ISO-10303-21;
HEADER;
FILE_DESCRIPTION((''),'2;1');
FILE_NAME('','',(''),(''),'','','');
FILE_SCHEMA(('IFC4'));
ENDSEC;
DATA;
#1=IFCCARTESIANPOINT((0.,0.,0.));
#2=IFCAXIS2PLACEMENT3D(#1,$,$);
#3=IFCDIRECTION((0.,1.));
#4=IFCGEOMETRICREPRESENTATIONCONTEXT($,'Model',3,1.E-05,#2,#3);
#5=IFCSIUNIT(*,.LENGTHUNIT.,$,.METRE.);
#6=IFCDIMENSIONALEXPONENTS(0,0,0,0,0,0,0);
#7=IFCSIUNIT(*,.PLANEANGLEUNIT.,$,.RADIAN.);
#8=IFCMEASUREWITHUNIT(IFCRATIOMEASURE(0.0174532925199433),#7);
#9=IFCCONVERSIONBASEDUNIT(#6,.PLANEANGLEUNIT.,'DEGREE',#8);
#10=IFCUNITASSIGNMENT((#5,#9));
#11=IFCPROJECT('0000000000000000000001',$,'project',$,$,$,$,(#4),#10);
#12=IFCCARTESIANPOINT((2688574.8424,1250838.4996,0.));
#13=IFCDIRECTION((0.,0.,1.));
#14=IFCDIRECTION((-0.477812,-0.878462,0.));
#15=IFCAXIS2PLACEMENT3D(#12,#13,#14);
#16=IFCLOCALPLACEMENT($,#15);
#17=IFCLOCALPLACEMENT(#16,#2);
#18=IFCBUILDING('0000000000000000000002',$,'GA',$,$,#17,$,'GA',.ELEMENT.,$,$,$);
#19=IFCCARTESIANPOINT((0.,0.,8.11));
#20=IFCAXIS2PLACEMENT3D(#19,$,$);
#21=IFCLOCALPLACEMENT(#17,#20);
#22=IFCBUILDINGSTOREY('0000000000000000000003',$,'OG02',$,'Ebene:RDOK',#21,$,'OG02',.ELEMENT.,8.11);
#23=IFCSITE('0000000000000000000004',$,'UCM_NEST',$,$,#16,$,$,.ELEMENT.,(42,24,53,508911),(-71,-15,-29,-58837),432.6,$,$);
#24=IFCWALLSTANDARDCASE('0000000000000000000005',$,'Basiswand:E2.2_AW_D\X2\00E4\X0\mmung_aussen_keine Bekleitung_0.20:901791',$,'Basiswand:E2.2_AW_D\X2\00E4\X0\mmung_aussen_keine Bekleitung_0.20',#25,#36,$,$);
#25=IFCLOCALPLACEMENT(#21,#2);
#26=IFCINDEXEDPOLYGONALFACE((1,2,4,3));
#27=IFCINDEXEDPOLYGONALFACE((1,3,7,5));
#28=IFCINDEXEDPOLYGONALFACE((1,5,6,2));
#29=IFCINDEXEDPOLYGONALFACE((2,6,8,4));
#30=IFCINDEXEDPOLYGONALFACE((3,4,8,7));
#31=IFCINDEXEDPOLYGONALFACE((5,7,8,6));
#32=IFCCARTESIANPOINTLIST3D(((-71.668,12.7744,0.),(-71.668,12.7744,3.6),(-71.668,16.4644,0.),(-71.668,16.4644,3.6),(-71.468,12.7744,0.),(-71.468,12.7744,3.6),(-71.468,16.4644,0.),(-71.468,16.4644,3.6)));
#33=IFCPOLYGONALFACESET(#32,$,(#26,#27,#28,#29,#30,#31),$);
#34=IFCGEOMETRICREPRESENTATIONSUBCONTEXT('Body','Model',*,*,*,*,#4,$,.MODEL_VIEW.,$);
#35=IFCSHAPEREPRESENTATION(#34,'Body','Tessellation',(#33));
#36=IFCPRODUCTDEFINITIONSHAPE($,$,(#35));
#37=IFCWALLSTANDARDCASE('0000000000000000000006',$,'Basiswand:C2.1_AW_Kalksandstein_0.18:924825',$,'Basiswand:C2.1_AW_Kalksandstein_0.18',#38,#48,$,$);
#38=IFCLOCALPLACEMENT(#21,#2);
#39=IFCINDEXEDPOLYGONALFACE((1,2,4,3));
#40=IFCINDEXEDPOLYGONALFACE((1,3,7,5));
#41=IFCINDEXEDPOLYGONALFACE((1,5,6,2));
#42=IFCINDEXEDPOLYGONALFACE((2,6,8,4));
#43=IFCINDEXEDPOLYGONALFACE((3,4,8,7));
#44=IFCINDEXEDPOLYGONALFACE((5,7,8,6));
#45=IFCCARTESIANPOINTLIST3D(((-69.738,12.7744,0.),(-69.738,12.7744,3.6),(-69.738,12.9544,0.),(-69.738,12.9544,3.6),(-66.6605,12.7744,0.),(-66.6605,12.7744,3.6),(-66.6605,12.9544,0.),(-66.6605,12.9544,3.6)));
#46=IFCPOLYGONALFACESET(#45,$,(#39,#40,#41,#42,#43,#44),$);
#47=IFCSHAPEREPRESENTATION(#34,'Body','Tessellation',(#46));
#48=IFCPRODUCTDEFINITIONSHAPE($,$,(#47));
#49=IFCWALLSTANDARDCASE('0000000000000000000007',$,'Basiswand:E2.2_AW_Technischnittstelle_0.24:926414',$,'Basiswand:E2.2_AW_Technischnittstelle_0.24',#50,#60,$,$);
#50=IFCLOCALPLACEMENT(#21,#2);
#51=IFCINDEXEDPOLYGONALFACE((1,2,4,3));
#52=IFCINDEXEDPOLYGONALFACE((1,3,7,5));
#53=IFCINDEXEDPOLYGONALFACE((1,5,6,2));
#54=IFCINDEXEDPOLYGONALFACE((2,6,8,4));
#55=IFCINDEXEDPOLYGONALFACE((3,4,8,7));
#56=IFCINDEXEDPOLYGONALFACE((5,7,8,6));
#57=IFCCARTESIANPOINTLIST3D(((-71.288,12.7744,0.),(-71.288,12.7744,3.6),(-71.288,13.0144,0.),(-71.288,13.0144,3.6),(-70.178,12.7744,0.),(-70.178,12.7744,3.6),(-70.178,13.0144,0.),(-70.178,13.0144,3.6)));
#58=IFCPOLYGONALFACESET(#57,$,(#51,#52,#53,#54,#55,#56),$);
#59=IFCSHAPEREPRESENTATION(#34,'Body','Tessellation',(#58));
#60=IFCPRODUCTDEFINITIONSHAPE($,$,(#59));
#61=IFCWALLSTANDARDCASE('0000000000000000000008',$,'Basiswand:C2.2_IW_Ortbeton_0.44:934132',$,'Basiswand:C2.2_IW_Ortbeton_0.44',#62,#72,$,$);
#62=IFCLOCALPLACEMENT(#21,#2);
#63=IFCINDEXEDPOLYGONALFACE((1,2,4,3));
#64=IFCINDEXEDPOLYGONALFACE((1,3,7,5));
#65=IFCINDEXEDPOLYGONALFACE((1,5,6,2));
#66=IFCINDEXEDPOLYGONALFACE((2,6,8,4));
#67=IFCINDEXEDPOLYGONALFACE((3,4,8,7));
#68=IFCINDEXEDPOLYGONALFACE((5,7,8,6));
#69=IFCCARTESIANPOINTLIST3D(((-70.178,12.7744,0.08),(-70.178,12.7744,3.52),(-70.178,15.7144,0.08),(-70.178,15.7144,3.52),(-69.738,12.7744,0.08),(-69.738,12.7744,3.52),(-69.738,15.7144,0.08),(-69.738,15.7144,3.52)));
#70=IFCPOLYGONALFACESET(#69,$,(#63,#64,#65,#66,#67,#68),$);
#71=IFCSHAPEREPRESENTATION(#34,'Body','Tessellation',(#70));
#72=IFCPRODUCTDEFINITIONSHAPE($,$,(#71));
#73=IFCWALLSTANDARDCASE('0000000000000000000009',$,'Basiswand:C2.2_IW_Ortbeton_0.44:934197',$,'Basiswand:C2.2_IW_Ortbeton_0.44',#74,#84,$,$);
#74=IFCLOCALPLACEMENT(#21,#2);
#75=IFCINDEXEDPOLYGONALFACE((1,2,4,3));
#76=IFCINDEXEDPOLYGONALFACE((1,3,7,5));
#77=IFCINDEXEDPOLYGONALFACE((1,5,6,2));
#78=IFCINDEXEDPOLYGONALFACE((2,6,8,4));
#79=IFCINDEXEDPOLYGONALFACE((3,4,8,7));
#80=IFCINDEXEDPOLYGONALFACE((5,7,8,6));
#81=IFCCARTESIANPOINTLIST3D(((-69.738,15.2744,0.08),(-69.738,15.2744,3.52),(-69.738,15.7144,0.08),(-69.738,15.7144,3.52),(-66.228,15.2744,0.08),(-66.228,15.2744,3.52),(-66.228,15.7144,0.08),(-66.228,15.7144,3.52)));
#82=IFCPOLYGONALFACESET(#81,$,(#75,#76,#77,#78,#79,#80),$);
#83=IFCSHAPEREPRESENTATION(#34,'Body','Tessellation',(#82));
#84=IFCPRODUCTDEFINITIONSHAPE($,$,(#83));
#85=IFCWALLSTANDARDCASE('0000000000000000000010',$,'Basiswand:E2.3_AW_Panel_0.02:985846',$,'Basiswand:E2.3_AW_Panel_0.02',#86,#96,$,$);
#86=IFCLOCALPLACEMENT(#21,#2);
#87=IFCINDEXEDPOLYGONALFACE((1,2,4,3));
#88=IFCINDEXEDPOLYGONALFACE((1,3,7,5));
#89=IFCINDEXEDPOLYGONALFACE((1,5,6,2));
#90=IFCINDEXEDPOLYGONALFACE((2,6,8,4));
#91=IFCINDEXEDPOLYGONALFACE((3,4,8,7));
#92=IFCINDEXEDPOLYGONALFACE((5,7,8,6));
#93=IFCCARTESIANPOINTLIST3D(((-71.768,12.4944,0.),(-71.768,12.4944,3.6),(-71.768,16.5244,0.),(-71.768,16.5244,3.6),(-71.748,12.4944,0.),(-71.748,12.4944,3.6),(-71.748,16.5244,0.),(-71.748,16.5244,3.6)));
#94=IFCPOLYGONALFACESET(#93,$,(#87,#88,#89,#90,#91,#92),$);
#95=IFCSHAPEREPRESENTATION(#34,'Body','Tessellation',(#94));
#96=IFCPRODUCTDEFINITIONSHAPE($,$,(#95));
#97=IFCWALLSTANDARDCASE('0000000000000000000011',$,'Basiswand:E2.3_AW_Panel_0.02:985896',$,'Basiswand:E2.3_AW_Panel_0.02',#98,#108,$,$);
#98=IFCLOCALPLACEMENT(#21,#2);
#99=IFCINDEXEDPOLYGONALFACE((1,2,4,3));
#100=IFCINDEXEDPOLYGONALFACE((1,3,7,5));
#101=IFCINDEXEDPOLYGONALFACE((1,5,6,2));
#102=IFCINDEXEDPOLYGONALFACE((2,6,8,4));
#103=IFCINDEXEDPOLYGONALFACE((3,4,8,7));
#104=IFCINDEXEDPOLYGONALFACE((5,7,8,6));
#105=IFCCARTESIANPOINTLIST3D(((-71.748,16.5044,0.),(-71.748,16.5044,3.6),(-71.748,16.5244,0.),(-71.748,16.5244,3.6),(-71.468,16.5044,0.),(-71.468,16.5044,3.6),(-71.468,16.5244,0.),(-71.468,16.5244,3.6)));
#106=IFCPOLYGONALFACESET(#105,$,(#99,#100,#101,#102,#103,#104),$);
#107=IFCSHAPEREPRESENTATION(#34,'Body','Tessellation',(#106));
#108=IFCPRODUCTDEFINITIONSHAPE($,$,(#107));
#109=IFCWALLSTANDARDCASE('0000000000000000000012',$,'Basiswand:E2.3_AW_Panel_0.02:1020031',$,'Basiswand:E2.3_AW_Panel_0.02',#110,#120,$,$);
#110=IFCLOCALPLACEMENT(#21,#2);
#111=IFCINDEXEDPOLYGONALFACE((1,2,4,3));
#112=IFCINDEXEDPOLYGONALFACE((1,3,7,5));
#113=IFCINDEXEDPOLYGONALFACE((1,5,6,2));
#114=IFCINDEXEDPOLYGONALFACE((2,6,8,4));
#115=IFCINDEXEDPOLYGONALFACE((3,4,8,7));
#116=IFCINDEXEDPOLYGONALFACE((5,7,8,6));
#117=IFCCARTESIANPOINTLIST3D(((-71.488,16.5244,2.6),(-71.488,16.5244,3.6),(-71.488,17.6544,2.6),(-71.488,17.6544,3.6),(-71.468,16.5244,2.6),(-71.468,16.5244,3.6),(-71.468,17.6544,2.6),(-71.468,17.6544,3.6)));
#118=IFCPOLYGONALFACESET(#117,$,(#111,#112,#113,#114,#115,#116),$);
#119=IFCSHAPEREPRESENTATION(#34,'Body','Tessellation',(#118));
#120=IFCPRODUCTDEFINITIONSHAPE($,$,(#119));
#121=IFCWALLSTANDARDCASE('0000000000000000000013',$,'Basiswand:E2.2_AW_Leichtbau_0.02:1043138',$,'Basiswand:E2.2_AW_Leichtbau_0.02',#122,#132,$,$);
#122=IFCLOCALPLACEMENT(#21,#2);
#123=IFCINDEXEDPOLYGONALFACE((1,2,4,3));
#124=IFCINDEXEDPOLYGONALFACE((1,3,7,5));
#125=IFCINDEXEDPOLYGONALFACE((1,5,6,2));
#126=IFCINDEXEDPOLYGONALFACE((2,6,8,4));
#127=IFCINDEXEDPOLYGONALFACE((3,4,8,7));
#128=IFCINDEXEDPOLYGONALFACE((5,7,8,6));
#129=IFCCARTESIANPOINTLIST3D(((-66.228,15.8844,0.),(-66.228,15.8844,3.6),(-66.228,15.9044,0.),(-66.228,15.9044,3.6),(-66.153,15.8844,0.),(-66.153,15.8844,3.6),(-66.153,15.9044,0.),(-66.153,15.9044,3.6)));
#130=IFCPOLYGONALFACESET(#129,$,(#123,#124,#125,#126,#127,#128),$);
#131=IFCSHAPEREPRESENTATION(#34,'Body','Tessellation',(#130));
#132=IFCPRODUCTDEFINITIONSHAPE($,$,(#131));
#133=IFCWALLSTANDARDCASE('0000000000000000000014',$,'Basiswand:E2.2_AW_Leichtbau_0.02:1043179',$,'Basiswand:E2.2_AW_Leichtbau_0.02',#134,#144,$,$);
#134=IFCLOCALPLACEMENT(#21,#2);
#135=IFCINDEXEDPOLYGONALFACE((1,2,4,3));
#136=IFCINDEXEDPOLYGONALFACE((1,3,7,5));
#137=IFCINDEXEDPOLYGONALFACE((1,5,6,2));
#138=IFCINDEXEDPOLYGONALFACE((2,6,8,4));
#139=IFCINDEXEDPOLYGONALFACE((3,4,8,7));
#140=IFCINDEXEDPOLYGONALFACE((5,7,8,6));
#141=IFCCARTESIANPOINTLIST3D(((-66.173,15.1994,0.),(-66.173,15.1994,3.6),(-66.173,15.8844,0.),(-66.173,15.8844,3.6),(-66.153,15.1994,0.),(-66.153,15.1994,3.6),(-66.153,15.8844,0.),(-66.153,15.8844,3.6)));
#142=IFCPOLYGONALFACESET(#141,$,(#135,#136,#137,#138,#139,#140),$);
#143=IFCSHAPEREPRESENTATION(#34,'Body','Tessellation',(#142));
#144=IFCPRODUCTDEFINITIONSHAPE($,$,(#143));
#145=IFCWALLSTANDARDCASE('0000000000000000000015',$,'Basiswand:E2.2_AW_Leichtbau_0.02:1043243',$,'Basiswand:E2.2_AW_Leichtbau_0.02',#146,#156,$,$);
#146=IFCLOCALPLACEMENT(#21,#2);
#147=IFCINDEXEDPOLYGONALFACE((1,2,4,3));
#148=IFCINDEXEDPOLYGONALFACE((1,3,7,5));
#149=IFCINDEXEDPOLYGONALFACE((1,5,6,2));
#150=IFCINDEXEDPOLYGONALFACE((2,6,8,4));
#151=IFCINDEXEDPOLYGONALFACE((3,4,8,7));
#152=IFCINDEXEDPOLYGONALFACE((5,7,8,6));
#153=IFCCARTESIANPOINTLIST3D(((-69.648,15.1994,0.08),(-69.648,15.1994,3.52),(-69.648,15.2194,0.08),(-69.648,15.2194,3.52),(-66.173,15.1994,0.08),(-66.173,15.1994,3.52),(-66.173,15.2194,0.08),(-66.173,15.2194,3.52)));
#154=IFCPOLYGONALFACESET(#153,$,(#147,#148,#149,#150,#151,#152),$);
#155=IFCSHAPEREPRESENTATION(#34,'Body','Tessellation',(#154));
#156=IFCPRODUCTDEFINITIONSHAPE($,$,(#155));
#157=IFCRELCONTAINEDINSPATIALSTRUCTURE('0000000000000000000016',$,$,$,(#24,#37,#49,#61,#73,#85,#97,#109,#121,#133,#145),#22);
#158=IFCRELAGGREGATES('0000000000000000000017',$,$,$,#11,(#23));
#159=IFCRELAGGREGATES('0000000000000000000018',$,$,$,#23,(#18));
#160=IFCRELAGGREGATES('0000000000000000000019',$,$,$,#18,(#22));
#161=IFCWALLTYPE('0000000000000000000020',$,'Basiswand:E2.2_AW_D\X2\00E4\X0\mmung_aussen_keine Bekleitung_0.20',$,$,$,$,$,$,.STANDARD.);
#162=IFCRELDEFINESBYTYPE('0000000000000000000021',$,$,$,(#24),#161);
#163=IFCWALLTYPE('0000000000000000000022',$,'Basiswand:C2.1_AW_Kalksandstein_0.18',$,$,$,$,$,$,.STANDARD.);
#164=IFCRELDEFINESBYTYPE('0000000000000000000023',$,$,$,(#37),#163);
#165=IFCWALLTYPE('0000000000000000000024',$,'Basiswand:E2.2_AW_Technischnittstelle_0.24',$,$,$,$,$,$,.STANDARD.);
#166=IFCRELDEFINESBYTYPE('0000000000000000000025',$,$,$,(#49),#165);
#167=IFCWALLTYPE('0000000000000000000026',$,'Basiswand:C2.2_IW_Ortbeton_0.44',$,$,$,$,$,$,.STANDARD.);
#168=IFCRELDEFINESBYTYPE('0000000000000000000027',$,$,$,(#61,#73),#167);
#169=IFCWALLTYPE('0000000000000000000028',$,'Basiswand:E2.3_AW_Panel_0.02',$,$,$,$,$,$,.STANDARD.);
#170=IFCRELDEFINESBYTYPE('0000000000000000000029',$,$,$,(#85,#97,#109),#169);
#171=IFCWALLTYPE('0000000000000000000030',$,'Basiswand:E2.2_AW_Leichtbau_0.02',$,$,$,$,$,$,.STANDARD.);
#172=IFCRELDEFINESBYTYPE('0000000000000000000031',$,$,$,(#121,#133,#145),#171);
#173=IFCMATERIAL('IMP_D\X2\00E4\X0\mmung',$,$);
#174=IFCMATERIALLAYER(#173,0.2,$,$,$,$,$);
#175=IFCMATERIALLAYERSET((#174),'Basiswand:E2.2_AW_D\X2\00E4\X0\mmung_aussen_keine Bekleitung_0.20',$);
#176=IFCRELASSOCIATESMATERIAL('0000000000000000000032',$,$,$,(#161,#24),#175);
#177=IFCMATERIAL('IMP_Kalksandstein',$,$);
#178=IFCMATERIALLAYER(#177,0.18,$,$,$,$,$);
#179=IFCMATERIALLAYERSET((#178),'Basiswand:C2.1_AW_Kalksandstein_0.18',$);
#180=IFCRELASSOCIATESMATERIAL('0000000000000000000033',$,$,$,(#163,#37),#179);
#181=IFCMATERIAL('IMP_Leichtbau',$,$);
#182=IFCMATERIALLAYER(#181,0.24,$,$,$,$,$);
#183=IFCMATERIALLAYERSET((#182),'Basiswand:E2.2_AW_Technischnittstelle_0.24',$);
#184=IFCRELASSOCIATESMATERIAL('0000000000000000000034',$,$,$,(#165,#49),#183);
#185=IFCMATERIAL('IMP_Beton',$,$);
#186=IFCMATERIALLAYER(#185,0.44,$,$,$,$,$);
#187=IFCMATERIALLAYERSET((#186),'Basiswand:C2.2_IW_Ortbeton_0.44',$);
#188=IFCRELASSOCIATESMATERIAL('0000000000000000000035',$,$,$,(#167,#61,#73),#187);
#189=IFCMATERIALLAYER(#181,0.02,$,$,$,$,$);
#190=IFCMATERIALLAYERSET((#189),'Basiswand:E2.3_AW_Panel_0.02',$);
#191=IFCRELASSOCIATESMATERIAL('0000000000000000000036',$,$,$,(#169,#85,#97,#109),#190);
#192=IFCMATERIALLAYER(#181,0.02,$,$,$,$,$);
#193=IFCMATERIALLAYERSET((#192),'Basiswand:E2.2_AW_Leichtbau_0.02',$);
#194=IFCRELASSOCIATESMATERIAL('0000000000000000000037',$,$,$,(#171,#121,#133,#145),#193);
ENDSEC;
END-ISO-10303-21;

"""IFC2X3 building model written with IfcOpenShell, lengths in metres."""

from ifc_helpers import new_model, entity, si_unit, converted_unit, direction, frame, frame_2d, origin, place, context, subcontext, project, spatial, polyline, rectangle, extrude, clip, bounded_halfspace, material, layer, layer_set, layer_usage, type_object, element, save


model = new_model("IFC2X3")

# Units and contexts
model_context = context("Model", 3, precision=1e-05, world=origin(), true_north=direction((0.0, 1.0)))
body_context = subcontext(model_context, "Body", "Model", "MODEL_VIEW")
ifc_project = project(units=[si_unit("LENGTHUNIT", "METRE"), converted_unit("PLANEANGLEUNIT", "DEGREE", entity("IfcRatioMeasure", 0.0174532925199433), si_unit("PLANEANGLEUNIT", "RADIAN"), dimensions=[0, 0, 0, 0, 0, 0, 0])], contexts=[model_context])

# Site, building, storey
site_placement = place(None, frame((2688574.8424, 1250838.4996, 0.0), z_axis=(0.0, 0.0, 1.0), x_axis=(-0.477812, -0.878462, 0.0)))
site = spatial("IfcSite", under=ifc_project, at=site_placement, Name="UCM_NEST", CompositionType="ELEMENT", RefLatitude=(42, 24, 53, 508911), RefLongitude=(-71, -15, -29, -58837), RefElevation=432.6)
building_placement = place(site_placement, origin())
building = spatial("IfcBuilding", under=site, at=building_placement, Name="GA", LongName="GA", CompositionType="ELEMENT")
storey_placement = place(building_placement, frame((0.0, 0.0, 8.11)))
storey = spatial("IfcBuildingStorey", under=building, at=storey_placement, Name="OG02", ObjectType="Ebene:RDOK", LongName="OG02", CompositionType="ELEMENT", Elevation=8.11)

# Walls
ifc_material_1 = material(Name="IMP_Dämmung")
ifc_layer_1 = layer(ifc_material_1, 0.2)
ifc_layer_set_1 = layer_set([ifc_layer_1], Name="Basiswand:E2.2_AW_Dämmung_aussen_keine Bekleitung_0.20")
ifc_layer_usage_1 = layer_usage(ifc_layer_set_1, "AXIS2", "NEGATIVE", 0.1)
wall_type_1 = type_object("IfcWallType", Name="Basiswand:E2.2_AW_Dämmung_aussen_keine Bekleitung_0.20", PredefinedType="STANDARD", material=ifc_layer_set_1)
wall_1_placement = place(storey_placement, frame((-71.568, 12.7744, 0.0), z_axis=(0.0, 0.0, 1.0), x_axis=(0.0, 1.0, 0.0)))
element("IfcWallStandardCase", 1, at=wall_1_placement, inside=storey, type_object=wall_type_1, material=ifc_layer_usage_1, Name="Basiswand:E2.2_AW_Dämmung_aussen_keine Bekleitung_0.20:901791", ObjectType="Basiswand:E2.2_AW_Dämmung_aussen_keine Bekleitung_0.20", context=body_context, shape_type="SweptSolid", body=[
    extrude(rectangle(XDim=3.69, YDim=0.2, at=frame_2d((1.845, 0.0), x_axis=(-1.0, 0.0))), origin(), (0.0, 0.0, 1.0), 3.6),
])
ifc_material_2 = material(Name="IMP_Kalksandstein")
ifc_layer_2 = layer(ifc_material_2, 0.18)
ifc_layer_set_2 = layer_set([ifc_layer_2], Name="Basiswand:C2.1_AW_Kalksandstein_0.18")
ifc_layer_usage_2 = layer_usage(ifc_layer_set_2, "AXIS2", "NEGATIVE", 0.09)
wall_type_2 = type_object("IfcWallType", Name="Basiswand:C2.1_AW_Kalksandstein_0.18", PredefinedType="STANDARD", material=ifc_layer_set_2)
wall_2_placement = place(storey_placement, frame((-66.6605, 12.8644, 0.0), z_axis=(0.0, 0.0, 1.0), x_axis=(-1.0, 0.0, 0.0)))
element("IfcWallStandardCase", 2, at=wall_2_placement, inside=storey, type_object=wall_type_2, material=ifc_layer_usage_2, Name="Basiswand:C2.1_AW_Kalksandstein_0.18:924825", ObjectType="Basiswand:C2.1_AW_Kalksandstein_0.18", context=body_context, shape_type="SweptSolid", body=[
    extrude(rectangle(XDim=3.0775, YDim=0.18, at=frame_2d((1.5388, 0.0), x_axis=(-1.0, 0.0))), origin(), (0.0, 0.0, 1.0), 3.6),
])
ifc_material_3 = material(Name="IMP_Leichtbau")
ifc_layer_3 = layer(ifc_material_3, 0.24)
ifc_layer_set_3 = layer_set([ifc_layer_3], Name="Basiswand:E2.2_AW_Technischnittstelle_0.24")
ifc_layer_usage_3 = layer_usage(ifc_layer_set_3, "AXIS2", "NEGATIVE", 0.12)
wall_type_3 = type_object("IfcWallType", Name="Basiswand:E2.2_AW_Technischnittstelle_0.24", PredefinedType="STANDARD", material=ifc_layer_set_3)
wall_3_placement = place(storey_placement, frame((-70.178, 12.8944, 0.0), z_axis=(0.0, 0.0, 1.0), x_axis=(-1.0, 0.0, 0.0)))
element("IfcWallStandardCase", 3, at=wall_3_placement, inside=storey, type_object=wall_type_3, material=ifc_layer_usage_3, Name="Basiswand:E2.2_AW_Technischnittstelle_0.24:926414", ObjectType="Basiswand:E2.2_AW_Technischnittstelle_0.24", context=body_context, shape_type="SweptSolid", body=[
    extrude(rectangle(XDim=1.11, YDim=0.24, at=frame_2d((0.555, 0.0), x_axis=(-1.0, 0.0))), origin(), (0.0, 0.0, 1.0), 3.6),
])

# Shared definitions
ifc_material_4 = material(Name="IMP_Beton")

# Walls
ifc_layer_4 = layer(ifc_material_4, 0.44)
ifc_layer_set_4 = layer_set([ifc_layer_4], Name="Basiswand:C2.2_IW_Ortbeton_0.44")
ifc_layer_usage_4 = layer_usage(ifc_layer_set_4, "AXIS2", "NEGATIVE", 0.22)
wall_type_4 = type_object("IfcWallType", Name="Basiswand:C2.2_IW_Ortbeton_0.44", PredefinedType="STANDARD", material=ifc_layer_set_4)
wall_4_placement = place(storey_placement, frame((-69.958, 12.7744, 0.08), z_axis=(0.0, 0.0, 1.0), x_axis=(0.0, 1.0, 0.0)))
element("IfcWallStandardCase", 4, at=wall_4_placement, inside=storey, type_object=wall_type_4, material=ifc_layer_usage_4, Name="Basiswand:C2.2_IW_Ortbeton_0.44:934132", ObjectType="Basiswand:C2.2_IW_Ortbeton_0.44", context=body_context, shape_type="Clipping", body=[
    clip(clip(extrude(rectangle(XDim=2.94, YDim=0.44, at=frame_2d((1.47, 0.0), x_axis=(-1.0, 0.0))), origin(), (0.0, 0.0, 1.0), 3.44), bounded_halfspace(frame((2.94, -0.22, 0.0), z_axis=(0.0, 0.0, 1.0), x_axis=(0.0, 1.0, 0.0)), True, frame((2.94, -0.22, 0.0), z_axis=(0.0, 0.0, 1.0), x_axis=(0.0, 1.0, 0.0)), polyline([(0.0, 0.0), (0.44, 0.0), (0.44, 2.94), (0.0, 2.94), (0.0, 2.76), (0.0, 0.44), (0.0, 0.0)]))), bounded_halfspace(frame((0.0, -0.22, 3.44), z_axis=(0.0, 0.0, -1.0), x_axis=(0.0, 1.0, 0.0)), True, frame((0.0, -0.22, 3.44), z_axis=(0.0, 0.0, -1.0), x_axis=(0.0, 1.0, 0.0)), polyline([(0.0, 0.0), (0.44, 0.0), (0.44, 2.94), (0.0, 2.94), (0.0, 2.5), (0.0, 0.18), (0.0, 0.0)]))),
])
ifc_layer_usage_5 = layer_usage(ifc_layer_set_4, "AXIS2", "NEGATIVE", 0.22)
wall_5_placement = place(storey_placement, frame((-69.738, 15.4944, 0.08)))
element("IfcWallStandardCase", 5, at=wall_5_placement, inside=storey, type_object=wall_type_4, material=ifc_layer_usage_5, Name="Basiswand:C2.2_IW_Ortbeton_0.44:934197", ObjectType="Basiswand:C2.2_IW_Ortbeton_0.44", context=body_context, shape_type="Clipping", body=[
    clip(clip(extrude(rectangle(XDim=3.51, YDim=0.44, at=frame_2d((1.755, 0.0), x_axis=(-1.0, 0.0))), origin(), (0.0, 0.0, 1.0), 3.44), bounded_halfspace(frame((0.0, -0.22, 3.44), z_axis=(0.0, 0.0, -1.0), x_axis=(-1.0, 0.0, 0.0)), True, frame((0.0, -0.22, 3.44), z_axis=(0.0, 0.0, -1.0), x_axis=(-1.0, 0.0, 0.0)), polyline([(0.0, 0.0), (0.0, 0.44), (-3.26, 0.44), (-3.51, 0.44), (-3.51, 0.0), (0.0, 0.0)]))), bounded_halfspace(frame((3.51, -0.22, 0.0), z_axis=(0.0, 0.0, 1.0), x_axis=(-1.0, 0.0, 0.0)), True, frame((3.51, -0.22, 0.0), z_axis=(0.0, 0.0, 1.0), x_axis=(-1.0, 0.0, 0.0)), polyline([(0.0, 0.0), (0.0, -0.44), (3.51, -0.44), (3.51, 0.0), (0.0, 0.0)]))),
])

# Walls
ifc_layer_5 = layer(ifc_material_3, 0.02)
ifc_layer_set_5 = layer_set([ifc_layer_5], Name="Basiswand:E2.3_AW_Panel_0.02")
ifc_layer_usage_6 = layer_usage(ifc_layer_set_5, "AXIS2", "NEGATIVE", 0.01)
wall_type_5 = type_object("IfcWallType", Name="Basiswand:E2.3_AW_Panel_0.02", PredefinedType="STANDARD", material=ifc_layer_set_5)
wall_6_placement = place(storey_placement, frame((-71.758, 12.4944, 0.0), z_axis=(0.0, 0.0, 1.0), x_axis=(0.0, 1.0, 0.0)))
element("IfcWallStandardCase", 6, at=wall_6_placement, inside=storey, type_object=wall_type_5, material=ifc_layer_usage_6, Name="Basiswand:E2.3_AW_Panel_0.02:985846", ObjectType="Basiswand:E2.3_AW_Panel_0.02", context=body_context, shape_type="SweptSolid", body=[
    extrude(rectangle(XDim=4.03, YDim=0.02, at=frame_2d((2.015, 0.0), x_axis=(-1.0, 0.0))), origin(), (0.0, 0.0, 1.0), 3.6),
])
ifc_layer_usage_7 = layer_usage(ifc_layer_set_5, "AXIS2", "NEGATIVE", 0.01)
wall_7_placement = place(storey_placement, frame((-71.748, 16.5144, 0.0)))
element("IfcWallStandardCase", 7, at=wall_7_placement, inside=storey, type_object=wall_type_5, material=ifc_layer_usage_7, Name="Basiswand:E2.3_AW_Panel_0.02:985896", ObjectType="Basiswand:E2.3_AW_Panel_0.02", context=body_context, shape_type="SweptSolid", body=[
    extrude(rectangle(XDim=0.28, YDim=0.02, at=frame_2d((0.14, 0.0), x_axis=(-1.0, 0.0))), origin(), (0.0, 0.0, 1.0), 3.6),
])
ifc_layer_usage_8 = layer_usage(ifc_layer_set_5, "AXIS2", "NEGATIVE", 0.01)
wall_8_placement = place(storey_placement, frame((-71.478, 16.5244, 2.6), z_axis=(0.0, 0.0, 1.0), x_axis=(0.0, 1.0, 0.0)))
element("IfcWallStandardCase", 8, at=wall_8_placement, inside=storey, type_object=wall_type_5, material=ifc_layer_usage_8, Name="Basiswand:E2.3_AW_Panel_0.02:1020031", ObjectType="Basiswand:E2.3_AW_Panel_0.02", context=body_context, shape_type="SweptSolid", body=[
    extrude(rectangle(XDim=1.13, YDim=0.02, at=frame_2d((0.565, 0.0), x_axis=(-1.0, 0.0))), origin(), (0.0, 0.0, 1.0), 1.0),
])

# Walls
ifc_layer_6 = layer(ifc_material_3, 0.02)
ifc_layer_set_6 = layer_set([ifc_layer_6], Name="Basiswand:E2.2_AW_Leichtbau_0.02")
ifc_layer_usage_9 = layer_usage(ifc_layer_set_6, "AXIS2", "NEGATIVE", 0.01)
wall_type_6 = type_object("IfcWallType", Name="Basiswand:E2.2_AW_Leichtbau_0.02", PredefinedType="STANDARD", material=ifc_layer_set_6)
wall_9_placement = place(storey_placement, frame((-66.228, 15.8944, 0.0)))
element("IfcWallStandardCase", 9, at=wall_9_placement, inside=storey, type_object=wall_type_6, material=ifc_layer_usage_9, Name="Basiswand:E2.2_AW_Leichtbau_0.02:1043138", ObjectType="Basiswand:E2.2_AW_Leichtbau_0.02", context=body_context, shape_type="SweptSolid", body=[
    extrude(rectangle(XDim=0.075, YDim=0.02, at=frame_2d((0.0375, 0.0), x_axis=(-1.0, 0.0))), origin(), (0.0, 0.0, 1.0), 3.6),
])
ifc_layer_usage_10 = layer_usage(ifc_layer_set_6, "AXIS2", "NEGATIVE", 0.01)
wall_10_placement = place(storey_placement, frame((-66.163, 15.8844, 0.0), z_axis=(0.0, 0.0, 1.0), x_axis=(0.0, -1.0, 0.0)))
element("IfcWallStandardCase", 10, at=wall_10_placement, inside=storey, type_object=wall_type_6, material=ifc_layer_usage_10, Name="Basiswand:E2.2_AW_Leichtbau_0.02:1043179", ObjectType="Basiswand:E2.2_AW_Leichtbau_0.02", context=body_context, shape_type="SweptSolid", body=[
    extrude(rectangle(XDim=0.685, YDim=0.02, at=frame_2d((0.3425, 0.0), x_axis=(-1.0, 0.0))), origin(), (0.0, 0.0, 1.0), 3.6),
])
ifc_layer_usage_11 = layer_usage(ifc_layer_set_6, "AXIS2", "NEGATIVE", 0.01)
wall_11_placement = place(storey_placement, frame((-66.173, 15.2094, 0.08), z_axis=(0.0, 0.0, 1.0), x_axis=(-1.0, 0.0, 0.0)))
element("IfcWallStandardCase", 11, at=wall_11_placement, inside=storey, type_object=wall_type_6, material=ifc_layer_usage_11, Name="Basiswand:E2.2_AW_Leichtbau_0.02:1043243", ObjectType="Basiswand:E2.2_AW_Leichtbau_0.02", context=body_context, shape_type="Clipping", body=[
    clip(clip(extrude(rectangle(XDim=3.475, YDim=0.02, at=frame_2d((1.7375, 0.0), x_axis=(-1.0, 0.0))), origin(), (0.0, 0.0, 1.0), 3.44), bounded_halfspace(frame((3.475, -0.01, 0.0)), True, frame((3.475, -0.01, 0.0)), polyline([(0.0, 0.0), (0.0, 0.02), (-3.475, 0.02), (-3.475, 0.0), (0.0, 0.0)]))), bounded_halfspace(frame((0.0, -0.01, 3.44), z_axis=(0.0, 0.0, -1.0), x_axis=(1.0, 0.0, 0.0)), True, frame((0.0, -0.01, 3.44), z_axis=(0.0, 0.0, -1.0), x_axis=(1.0, 0.0, 0.0)), polyline([(0.0, 0.0), (0.0, -0.02), (3.475, -0.02), (3.475, 0.0), (0.0, 0.0)]))),
])

save(model, "model.ifc")
